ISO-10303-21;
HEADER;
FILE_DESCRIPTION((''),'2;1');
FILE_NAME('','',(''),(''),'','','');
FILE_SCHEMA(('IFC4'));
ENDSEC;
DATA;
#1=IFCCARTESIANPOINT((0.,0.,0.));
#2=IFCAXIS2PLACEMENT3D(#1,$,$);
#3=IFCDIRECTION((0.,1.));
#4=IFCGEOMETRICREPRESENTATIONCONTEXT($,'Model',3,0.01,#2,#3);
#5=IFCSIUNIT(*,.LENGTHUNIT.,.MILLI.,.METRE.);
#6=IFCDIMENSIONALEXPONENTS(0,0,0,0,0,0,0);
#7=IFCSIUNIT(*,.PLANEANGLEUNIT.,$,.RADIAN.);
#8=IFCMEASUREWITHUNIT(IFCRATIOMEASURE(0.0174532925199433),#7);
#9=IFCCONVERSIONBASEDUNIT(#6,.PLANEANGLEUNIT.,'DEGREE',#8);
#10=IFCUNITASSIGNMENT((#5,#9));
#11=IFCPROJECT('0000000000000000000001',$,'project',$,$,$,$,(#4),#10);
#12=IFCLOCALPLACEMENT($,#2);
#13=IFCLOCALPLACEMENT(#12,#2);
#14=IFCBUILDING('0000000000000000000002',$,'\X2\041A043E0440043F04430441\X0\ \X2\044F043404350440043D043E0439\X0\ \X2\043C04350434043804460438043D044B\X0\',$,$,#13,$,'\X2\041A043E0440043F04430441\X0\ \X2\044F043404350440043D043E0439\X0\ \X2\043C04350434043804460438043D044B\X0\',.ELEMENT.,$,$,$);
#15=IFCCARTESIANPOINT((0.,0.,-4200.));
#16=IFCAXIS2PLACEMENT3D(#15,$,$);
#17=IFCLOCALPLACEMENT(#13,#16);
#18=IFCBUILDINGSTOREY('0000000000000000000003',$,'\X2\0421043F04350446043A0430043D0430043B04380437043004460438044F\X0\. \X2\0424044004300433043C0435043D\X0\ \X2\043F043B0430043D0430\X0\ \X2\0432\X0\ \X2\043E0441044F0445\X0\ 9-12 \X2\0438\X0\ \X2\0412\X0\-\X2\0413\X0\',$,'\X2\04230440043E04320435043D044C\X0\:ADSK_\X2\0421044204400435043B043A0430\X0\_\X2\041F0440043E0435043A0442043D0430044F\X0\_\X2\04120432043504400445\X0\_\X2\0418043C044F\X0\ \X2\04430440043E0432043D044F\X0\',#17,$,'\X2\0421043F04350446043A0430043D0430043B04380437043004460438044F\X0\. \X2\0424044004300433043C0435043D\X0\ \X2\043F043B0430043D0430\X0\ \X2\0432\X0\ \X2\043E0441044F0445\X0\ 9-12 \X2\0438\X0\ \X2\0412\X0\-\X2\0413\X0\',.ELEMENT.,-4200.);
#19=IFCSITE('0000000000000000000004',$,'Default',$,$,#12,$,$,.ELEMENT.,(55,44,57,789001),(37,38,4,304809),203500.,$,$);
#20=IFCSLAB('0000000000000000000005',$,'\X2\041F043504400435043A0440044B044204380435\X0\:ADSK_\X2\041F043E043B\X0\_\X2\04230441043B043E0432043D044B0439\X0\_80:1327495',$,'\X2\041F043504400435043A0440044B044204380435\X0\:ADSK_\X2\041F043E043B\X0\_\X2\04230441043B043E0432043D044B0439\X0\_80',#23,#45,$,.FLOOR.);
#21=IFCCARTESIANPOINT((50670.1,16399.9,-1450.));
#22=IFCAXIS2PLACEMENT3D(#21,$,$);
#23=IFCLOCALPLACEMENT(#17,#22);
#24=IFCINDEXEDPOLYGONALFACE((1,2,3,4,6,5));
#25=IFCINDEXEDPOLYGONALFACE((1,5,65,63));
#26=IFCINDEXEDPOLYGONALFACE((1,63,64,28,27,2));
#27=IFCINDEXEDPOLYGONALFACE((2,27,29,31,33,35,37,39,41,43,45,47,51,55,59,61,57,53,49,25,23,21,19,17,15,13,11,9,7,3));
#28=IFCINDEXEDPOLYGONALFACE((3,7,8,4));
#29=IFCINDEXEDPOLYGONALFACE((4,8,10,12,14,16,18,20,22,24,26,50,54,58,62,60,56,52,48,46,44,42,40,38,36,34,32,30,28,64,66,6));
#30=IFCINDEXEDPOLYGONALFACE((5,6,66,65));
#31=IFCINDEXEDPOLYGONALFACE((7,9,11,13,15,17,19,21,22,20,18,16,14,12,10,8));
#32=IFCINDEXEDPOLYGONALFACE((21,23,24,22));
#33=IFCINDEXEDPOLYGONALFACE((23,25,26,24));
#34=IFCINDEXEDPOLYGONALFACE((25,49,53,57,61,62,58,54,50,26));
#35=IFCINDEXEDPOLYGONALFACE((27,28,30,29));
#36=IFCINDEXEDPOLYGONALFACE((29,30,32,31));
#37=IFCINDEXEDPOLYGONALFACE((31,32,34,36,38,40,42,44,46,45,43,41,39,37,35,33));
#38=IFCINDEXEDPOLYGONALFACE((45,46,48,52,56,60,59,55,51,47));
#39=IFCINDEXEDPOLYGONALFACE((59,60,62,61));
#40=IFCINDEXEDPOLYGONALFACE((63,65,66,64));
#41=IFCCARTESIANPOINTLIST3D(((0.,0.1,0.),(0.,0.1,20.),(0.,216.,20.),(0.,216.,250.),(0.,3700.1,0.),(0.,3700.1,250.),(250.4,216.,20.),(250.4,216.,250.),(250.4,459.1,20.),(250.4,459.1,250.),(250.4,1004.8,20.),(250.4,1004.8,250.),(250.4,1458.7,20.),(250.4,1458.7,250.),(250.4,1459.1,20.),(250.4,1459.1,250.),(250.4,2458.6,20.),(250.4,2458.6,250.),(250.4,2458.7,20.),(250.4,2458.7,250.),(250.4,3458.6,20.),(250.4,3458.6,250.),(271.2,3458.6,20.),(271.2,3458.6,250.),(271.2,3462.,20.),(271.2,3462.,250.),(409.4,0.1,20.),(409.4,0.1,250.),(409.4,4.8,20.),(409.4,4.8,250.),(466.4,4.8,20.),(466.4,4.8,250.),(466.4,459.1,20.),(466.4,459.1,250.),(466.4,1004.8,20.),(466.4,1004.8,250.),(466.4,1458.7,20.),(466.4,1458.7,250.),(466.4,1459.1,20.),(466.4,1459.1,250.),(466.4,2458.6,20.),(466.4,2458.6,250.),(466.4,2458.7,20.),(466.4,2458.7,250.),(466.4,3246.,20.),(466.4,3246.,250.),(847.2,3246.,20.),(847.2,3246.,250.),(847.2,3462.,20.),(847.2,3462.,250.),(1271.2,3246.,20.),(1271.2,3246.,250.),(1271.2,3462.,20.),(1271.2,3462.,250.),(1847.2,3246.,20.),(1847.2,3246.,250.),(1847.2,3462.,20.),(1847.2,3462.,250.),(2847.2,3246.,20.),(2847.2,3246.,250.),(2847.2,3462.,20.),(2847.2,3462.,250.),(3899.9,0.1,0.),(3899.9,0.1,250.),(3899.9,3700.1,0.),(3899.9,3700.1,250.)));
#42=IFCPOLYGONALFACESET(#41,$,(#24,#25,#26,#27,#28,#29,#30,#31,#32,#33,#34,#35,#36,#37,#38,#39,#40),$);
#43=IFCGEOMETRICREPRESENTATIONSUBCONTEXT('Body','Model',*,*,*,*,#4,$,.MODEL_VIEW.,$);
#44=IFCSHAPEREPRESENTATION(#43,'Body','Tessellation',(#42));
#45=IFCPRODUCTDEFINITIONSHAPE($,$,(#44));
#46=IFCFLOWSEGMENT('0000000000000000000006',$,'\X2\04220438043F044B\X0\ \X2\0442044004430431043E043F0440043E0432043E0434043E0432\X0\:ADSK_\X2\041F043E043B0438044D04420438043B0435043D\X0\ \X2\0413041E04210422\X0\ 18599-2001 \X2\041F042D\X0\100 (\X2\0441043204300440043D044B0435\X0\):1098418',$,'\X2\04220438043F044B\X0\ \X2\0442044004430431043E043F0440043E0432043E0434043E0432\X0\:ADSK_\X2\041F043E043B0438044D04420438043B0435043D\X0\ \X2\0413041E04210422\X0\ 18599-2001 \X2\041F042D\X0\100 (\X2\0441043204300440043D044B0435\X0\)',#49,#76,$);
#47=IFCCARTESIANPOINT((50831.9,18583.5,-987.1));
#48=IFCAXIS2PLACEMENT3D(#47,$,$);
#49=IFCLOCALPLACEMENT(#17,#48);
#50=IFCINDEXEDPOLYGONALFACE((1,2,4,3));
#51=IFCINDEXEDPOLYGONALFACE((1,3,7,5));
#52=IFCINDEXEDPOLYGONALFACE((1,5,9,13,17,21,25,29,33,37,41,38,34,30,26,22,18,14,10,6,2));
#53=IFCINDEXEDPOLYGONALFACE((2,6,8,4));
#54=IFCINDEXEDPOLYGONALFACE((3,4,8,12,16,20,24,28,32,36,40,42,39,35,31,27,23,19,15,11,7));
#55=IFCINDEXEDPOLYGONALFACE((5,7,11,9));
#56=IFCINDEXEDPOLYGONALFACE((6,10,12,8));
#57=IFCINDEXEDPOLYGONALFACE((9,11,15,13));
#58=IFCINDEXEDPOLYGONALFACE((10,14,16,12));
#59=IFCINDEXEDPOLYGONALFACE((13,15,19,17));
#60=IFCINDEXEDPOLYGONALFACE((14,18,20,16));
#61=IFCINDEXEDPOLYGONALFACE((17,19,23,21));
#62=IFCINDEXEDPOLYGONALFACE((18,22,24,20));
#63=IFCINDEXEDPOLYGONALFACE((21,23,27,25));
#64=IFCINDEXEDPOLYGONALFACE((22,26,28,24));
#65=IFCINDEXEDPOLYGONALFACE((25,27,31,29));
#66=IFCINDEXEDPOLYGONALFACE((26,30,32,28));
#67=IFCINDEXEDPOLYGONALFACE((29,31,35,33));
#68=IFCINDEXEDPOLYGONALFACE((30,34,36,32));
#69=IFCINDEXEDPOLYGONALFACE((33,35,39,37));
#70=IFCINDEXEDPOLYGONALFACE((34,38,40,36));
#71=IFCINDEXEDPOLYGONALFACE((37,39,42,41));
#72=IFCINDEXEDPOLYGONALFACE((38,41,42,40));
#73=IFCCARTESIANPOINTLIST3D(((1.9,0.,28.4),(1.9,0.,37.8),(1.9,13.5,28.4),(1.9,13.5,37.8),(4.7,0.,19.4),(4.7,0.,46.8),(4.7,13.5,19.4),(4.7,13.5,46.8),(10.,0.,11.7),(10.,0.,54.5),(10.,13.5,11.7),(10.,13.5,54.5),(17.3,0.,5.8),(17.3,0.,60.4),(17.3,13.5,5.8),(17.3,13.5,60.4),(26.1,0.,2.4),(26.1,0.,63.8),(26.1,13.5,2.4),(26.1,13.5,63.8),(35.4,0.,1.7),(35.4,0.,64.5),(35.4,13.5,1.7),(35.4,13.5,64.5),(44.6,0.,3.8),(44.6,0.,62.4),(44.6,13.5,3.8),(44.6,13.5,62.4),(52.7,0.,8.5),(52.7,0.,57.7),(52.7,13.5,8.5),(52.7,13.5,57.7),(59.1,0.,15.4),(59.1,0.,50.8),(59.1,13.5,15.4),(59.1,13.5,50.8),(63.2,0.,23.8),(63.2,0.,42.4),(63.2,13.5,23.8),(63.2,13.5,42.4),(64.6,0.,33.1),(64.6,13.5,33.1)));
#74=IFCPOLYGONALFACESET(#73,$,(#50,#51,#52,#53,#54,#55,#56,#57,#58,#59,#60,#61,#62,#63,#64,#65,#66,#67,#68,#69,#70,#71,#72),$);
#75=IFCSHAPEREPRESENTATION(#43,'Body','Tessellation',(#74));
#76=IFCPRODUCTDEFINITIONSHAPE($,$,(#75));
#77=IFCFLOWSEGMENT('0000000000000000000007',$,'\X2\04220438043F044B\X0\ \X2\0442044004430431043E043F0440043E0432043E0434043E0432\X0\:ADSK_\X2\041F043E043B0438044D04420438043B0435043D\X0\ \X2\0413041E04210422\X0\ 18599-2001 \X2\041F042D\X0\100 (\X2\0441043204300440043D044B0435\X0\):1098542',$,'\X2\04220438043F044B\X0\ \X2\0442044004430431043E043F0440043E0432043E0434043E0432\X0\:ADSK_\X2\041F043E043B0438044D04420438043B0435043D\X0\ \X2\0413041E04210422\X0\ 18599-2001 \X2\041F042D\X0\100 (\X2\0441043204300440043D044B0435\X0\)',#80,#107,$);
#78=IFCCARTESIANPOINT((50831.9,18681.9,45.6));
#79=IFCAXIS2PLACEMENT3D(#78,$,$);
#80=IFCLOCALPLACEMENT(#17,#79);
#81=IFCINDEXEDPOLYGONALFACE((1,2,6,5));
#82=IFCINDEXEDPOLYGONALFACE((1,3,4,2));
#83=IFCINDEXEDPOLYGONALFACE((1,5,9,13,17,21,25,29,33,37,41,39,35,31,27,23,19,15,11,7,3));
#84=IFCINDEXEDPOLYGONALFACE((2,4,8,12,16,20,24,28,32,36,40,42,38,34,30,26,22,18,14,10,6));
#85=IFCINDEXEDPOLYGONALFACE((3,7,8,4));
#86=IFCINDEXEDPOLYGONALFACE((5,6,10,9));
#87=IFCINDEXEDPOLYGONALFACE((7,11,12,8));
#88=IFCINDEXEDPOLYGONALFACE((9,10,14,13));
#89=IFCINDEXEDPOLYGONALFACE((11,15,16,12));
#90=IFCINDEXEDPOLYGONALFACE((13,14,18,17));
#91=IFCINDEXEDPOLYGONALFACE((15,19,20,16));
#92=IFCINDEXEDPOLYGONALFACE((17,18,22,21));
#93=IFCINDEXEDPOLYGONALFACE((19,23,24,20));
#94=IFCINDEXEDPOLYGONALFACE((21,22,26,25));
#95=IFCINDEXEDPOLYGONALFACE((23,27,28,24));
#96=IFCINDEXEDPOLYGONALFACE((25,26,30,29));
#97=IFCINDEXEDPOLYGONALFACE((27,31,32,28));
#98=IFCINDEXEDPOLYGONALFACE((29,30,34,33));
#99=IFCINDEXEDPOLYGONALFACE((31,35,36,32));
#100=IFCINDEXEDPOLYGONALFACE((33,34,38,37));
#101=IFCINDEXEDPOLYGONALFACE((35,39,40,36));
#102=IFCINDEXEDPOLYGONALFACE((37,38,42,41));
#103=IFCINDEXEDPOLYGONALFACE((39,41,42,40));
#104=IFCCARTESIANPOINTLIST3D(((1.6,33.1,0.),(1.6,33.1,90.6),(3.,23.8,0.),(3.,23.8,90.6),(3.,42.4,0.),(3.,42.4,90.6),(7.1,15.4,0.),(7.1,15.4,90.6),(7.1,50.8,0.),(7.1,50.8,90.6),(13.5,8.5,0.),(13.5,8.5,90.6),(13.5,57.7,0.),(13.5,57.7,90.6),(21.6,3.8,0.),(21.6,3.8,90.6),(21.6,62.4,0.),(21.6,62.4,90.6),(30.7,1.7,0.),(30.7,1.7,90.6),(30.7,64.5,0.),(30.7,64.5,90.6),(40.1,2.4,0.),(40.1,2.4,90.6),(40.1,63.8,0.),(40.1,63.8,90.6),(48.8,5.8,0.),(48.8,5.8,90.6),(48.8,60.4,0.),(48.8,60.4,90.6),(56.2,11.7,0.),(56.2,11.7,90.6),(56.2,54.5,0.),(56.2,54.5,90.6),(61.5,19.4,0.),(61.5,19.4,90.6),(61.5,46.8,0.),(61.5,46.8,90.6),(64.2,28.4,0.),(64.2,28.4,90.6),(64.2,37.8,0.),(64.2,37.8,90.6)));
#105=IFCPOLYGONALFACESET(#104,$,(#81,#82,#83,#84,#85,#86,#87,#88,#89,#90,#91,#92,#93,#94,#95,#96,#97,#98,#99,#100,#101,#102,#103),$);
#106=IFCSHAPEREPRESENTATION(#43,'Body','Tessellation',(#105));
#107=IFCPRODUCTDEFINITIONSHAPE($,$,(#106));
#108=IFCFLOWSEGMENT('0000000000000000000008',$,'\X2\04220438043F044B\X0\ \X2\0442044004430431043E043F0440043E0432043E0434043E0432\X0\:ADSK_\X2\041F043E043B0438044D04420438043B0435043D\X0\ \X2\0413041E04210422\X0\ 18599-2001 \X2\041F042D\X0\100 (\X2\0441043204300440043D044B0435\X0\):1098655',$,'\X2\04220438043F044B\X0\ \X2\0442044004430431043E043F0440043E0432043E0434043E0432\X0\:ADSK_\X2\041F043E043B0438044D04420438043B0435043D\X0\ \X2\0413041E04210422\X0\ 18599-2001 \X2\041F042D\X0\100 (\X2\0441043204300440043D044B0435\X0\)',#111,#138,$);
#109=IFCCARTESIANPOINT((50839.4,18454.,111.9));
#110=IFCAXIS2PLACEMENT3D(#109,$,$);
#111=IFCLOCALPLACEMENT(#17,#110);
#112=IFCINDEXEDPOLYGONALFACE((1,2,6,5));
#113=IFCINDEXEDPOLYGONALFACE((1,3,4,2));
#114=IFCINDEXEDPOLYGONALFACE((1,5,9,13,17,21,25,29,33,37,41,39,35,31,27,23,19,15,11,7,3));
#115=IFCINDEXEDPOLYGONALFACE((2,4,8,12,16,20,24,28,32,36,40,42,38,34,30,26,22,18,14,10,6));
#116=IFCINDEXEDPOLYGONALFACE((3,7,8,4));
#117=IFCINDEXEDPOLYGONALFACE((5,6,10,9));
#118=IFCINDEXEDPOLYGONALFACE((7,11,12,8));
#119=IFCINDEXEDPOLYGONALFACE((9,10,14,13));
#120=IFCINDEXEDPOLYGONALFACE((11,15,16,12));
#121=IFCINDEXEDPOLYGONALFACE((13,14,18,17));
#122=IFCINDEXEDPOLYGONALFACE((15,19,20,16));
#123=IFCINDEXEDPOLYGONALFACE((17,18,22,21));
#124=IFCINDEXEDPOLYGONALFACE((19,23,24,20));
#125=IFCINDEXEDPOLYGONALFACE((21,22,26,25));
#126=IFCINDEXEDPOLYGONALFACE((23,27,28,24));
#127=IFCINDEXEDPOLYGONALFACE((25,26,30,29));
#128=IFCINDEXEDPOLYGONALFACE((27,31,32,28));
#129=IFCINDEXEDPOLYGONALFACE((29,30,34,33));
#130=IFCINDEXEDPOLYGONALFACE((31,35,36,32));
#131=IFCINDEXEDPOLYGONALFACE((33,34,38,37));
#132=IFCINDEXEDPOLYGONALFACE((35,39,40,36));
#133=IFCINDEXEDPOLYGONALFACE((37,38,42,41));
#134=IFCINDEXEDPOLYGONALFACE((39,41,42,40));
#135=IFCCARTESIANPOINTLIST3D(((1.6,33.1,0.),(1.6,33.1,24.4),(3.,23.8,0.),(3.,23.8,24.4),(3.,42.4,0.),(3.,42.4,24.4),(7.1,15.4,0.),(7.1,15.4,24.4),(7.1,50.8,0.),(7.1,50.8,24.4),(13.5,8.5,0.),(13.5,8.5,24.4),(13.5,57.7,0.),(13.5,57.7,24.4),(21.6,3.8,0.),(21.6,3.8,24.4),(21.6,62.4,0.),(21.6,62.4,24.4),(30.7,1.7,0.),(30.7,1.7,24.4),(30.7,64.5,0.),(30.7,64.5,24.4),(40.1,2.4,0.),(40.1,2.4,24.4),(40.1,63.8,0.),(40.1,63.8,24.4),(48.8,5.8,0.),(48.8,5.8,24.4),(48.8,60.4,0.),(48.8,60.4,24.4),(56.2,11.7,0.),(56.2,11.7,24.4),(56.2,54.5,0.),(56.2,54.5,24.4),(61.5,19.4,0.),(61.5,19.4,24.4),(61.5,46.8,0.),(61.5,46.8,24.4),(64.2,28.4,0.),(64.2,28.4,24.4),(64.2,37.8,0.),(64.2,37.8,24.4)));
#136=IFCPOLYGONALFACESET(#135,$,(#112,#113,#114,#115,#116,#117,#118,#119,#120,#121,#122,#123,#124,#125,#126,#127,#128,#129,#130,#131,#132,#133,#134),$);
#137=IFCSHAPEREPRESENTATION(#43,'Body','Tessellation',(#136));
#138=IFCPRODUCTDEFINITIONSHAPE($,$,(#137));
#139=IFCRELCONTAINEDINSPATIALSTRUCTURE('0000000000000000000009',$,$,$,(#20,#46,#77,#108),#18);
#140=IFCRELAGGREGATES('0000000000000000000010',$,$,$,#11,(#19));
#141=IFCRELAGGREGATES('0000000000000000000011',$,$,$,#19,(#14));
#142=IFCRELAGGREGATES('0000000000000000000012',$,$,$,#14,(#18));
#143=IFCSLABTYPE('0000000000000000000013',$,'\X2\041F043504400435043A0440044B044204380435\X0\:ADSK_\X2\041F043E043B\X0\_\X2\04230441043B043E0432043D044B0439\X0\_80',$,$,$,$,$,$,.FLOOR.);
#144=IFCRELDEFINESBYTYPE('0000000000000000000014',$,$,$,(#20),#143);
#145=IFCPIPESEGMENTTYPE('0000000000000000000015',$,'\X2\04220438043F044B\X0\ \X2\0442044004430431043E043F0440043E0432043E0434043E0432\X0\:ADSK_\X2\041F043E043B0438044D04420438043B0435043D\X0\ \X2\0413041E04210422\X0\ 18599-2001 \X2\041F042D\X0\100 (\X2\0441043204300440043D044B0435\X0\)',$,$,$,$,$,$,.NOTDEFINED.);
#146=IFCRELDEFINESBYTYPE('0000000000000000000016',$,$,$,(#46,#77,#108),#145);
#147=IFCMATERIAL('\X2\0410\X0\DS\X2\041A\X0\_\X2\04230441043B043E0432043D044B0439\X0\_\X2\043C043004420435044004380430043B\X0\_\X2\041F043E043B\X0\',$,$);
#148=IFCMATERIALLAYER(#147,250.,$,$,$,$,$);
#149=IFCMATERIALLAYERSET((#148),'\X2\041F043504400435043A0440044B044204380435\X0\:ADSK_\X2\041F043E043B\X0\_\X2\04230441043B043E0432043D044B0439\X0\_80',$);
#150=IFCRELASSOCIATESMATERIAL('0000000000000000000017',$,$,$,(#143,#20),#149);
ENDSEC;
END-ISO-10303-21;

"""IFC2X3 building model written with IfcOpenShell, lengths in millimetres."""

from ifc_helpers import new_model, entity, si_unit, converted_unit, direction, frame, frame_2d, origin, origin_2d_with_axis, place, context, subcontext, project, spatial, rectangle, circle, extrude, material, layer, layer_set, layer_usage, type_object, element, save


model = new_model("IFC2X3")

# Units and contexts
model_context = context("Model", 3, precision=0.01, world=origin(), true_north=direction((0.0, 1.0)))
body_context = subcontext(model_context, "Body", "Model", "MODEL_VIEW")
ifc_project = project(units=[si_unit("LENGTHUNIT", "METRE", prefix="MILLI"), converted_unit("PLANEANGLEUNIT", "DEGREE", entity("IfcRatioMeasure", 0.0174532925199433), si_unit("PLANEANGLEUNIT", "RADIAN"), dimensions=[0, 0, 0, 0, 0, 0, 0])], contexts=[model_context])

# Site, building, storey
site_placement = place(None, frame((0.0, 0.0, 0.0)))
site = spatial("IfcSite", under=ifc_project, at=site_placement, Name="Default", CompositionType="ELEMENT", RefLatitude=(55, 44, 57, 789001), RefLongitude=(37, 38, 4, 304809), RefElevation=203500.0)
building_placement = place(site_placement, origin())
building = spatial("IfcBuilding", under=site, at=building_placement, Name="Корпус ядерной медицины", LongName="Корпус ядерной медицины", CompositionType="ELEMENT")
storey_placement = place(building_placement, frame((0.0, 0.0, -4200.0)))
storey = spatial("IfcBuildingStorey", under=building, at=storey_placement, Name="Спецканализация. Фрагмен плана в осях 9-12 и В-Г", ObjectType="Уровень:ADSK_Стрелка_Проектная_Вверх_Имя уровня", LongName="Спецканализация. Фрагмен плана в осях 9-12 и В-Г", CompositionType="ELEMENT", Elevation=-4200.0)

# Slab, openings
ifc_material_1 = material(Name="АDSК_Условный_материал_Пол")
ifc_layer = layer(ifc_material_1, 250.0)
ifc_layer_set = layer_set([ifc_layer], Name="Перекрытие:ADSK_Пол_Условный_80")
ifc_layer_usage = layer_usage(ifc_layer_set, "AXIS3", "POSITIVE", 0.0)
slab_type = type_object("IfcSlabType", Name="Перекрытие:ADSK_Пол_Условный_80", PredefinedType="FLOOR", material=ifc_layer_set)
slab_placement = place(storey_placement, frame((50670.1, 16399.9, -1450.0)))
slab = element("IfcSlab", 1, at=slab_placement, inside=storey, type_object=slab_type, material=ifc_layer_usage, Name="Перекрытие:ADSK_Пол_Условный_80:1327495", ObjectType="Перекрытие:ADSK_Пол_Условный_80", PredefinedType="FLOOR", context=body_context, shape_type="SweptSolid", body=[
    extrude(rectangle(XDim=3899.9, YDim=3700.0, at=frame_2d((0.0, 0.0), x_axis=(-1.0, 0.0))), frame((1949.9, 1850.1, 250.0), z_axis=(0.0, 0.0, -1.0), x_axis=(-1.0, 0.0, 0.0)), (0.0, 0.0, 1.0), 250.0),
])
opening_1_placement = place(slab_placement, origin())
element("IfcOpeningElement", 2, at=opening_1_placement, cuts=slab, ObjectType="Opening", context=body_context, shape_type="SweptSolid", body=[
    extrude(rectangle(XDim=1000.0, YDim=216.0, at=origin_2d_with_axis()), frame((771.2, 3354.0, 20.0)), (0.0, 0.0, 1.0), 305.0),
])
opening_2_placement = place(slab_placement, origin())
element("IfcOpeningElement", 3, at=opening_2_placement, cuts=slab, ObjectType="Opening", context=body_context, shape_type="SweptSolid", body=[
    extrude(rectangle(XDim=1000.0, YDim=216.0, at=origin_2d_with_axis()), frame((2347.2, 3354.0, 20.0)), (0.0, 0.0, 1.0), 305.0),
])
opening_3_placement = place(slab_placement, origin())
element("IfcOpeningElement", 4, at=opening_3_placement, cuts=slab, ObjectType="Opening", context=body_context, shape_type="SweptSolid", body=[
    extrude(rectangle(XDim=1000.0, YDim=216.0, at=origin_2d_with_axis()), frame((358.4, 2958.6, 20.0), z_axis=(0.0, 0.0, 1.0), x_axis=(0.0, 1.0, 0.0)), (0.0, 0.0, 1.0), 305.0),
])
opening_4_placement = place(slab_placement, origin())
element("IfcOpeningElement", 5, at=opening_4_placement, cuts=slab, ObjectType="Opening", context=body_context, shape_type="SweptSolid", body=[
    extrude(rectangle(XDim=1000.0, YDim=216.0, at=origin_2d_with_axis()), frame((1347.2, 3354.0, 20.0)), (0.0, 0.0, 1.0), 305.0),
])
opening_5_placement = place(slab_placement, origin())
element("IfcOpeningElement", 6, at=opening_5_placement, cuts=slab, ObjectType="Opening", context=body_context, shape_type="SweptSolid", body=[
    extrude(rectangle(XDim=1000.0, YDim=216.0, at=origin_2d_with_axis()), frame((358.4, 504.8, 20.0), z_axis=(0.0, 0.0, 1.0), x_axis=(0.0, 1.0, 0.0)), (0.0, 0.0, 1.0), 305.0),
])
opening_6_placement = place(slab_placement, origin())
element("IfcOpeningElement", 7, at=opening_6_placement, cuts=slab, ObjectType="Opening", context=body_context, shape_type="SweptSolid", body=[
    extrude(rectangle(XDim=1000.0, YDim=216.0, at=origin_2d_with_axis()), frame((358.4, 1958.7, 20.0), z_axis=(0.0, 0.0, 1.0), x_axis=(0.0, 1.0, 0.0)), (0.0, 0.0, 1.0), 305.0),
])
opening_7_placement = place(slab_placement, origin())
element("IfcOpeningElement", 8, at=opening_7_placement, cuts=slab, ObjectType="Opening", context=body_context, shape_type="SweptSolid", body=[
    extrude(rectangle(XDim=1000.0, YDim=216.0, at=origin_2d_with_axis()), frame((-90.6, 108.0, 20.0), z_axis=(0.0, 0.0, 1.0), x_axis=(-1.0, 0.0, 0.0)), (0.0, 0.0, 1.0), 305.0),
])
opening_8_placement = place(slab_placement, origin())
element("IfcOpeningElement", 9, at=opening_8_placement, cuts=slab, ObjectType="Opening", context=body_context, shape_type="SweptSolid", body=[
    extrude(rectangle(XDim=1000.0, YDim=216.0, at=origin_2d_with_axis()), frame((358.4, 959.1, 20.0), z_axis=(0.0, 0.0, 1.0), x_axis=(0.0, 1.0, 0.0)), (0.0, 0.0, 1.0), 305.0),
])

# Flow segments
pipe_segment_type = type_object("IfcPipeSegmentType", Name="Типы трубопроводов:ADSK_Полиэтилен ГОСТ 18599-2001 ПЭ100 (сварные)", PredefinedType="NOTDEFINED")
flow_segment_1_placement = place(storey_placement, frame((50831.9, 18583.5, -987.1)))
element("IfcFlowSegment", 10, at=flow_segment_1_placement, inside=storey, type_object=pipe_segment_type, Name="Типы трубопроводов:ADSK_Полиэтилен ГОСТ 18599-2001 ПЭ100 (сварные):1098418", ObjectType="Типы трубопроводов:ADSK_Полиэтилен ГОСТ 18599-2001 ПЭ100 (сварные)", context=body_context, shape_type="SweptSolid", body=[
    extrude(circle(Radius=31.5, at=origin_2d_with_axis()), frame((33.1, 0.0, 33.1), z_axis=(0.0, 1.0, 0.0), x_axis=(1.0, 0.0, 0.0)), (0.0, 0.0, 1.0), 13.5),
])
flow_segment_2_placement = place(storey_placement, frame((50831.9, 18681.9, 45.6)))
element("IfcFlowSegment", 11, at=flow_segment_2_placement, inside=storey, type_object=pipe_segment_type, Name="Типы трубопроводов:ADSK_Полиэтилен ГОСТ 18599-2001 ПЭ100 (сварные):1098542", ObjectType="Типы трубопроводов:ADSK_Полиэтилен ГОСТ 18599-2001 ПЭ100 (сварные)", context=body_context, shape_type="SweptSolid", body=[
    extrude(circle(Radius=31.5, at=origin_2d_with_axis()), frame((33.1, 33.1, 0.0), z_axis=(0.0, 0.0, 1.0), x_axis=(-1.0, 0.0, 0.0)), (0.0, 0.0, 1.0), 90.6),
])
flow_segment_3_placement = place(storey_placement, frame((50839.4, 18454.0, 111.9)))
element("IfcFlowSegment", 12, at=flow_segment_3_placement, inside=storey, type_object=pipe_segment_type, Name="Типы трубопроводов:ADSK_Полиэтилен ГОСТ 18599-2001 ПЭ100 (сварные):1098655", ObjectType="Типы трубопроводов:ADSK_Полиэтилен ГОСТ 18599-2001 ПЭ100 (сварные)", context=body_context, shape_type="SweptSolid", body=[
    extrude(circle(Radius=31.5, at=frame_2d((0.0, 0.0), x_axis=(1.0, 0.0))), frame((33.1, 33.1, 0.0), z_axis=(0.0, 0.0, 1.0), x_axis=(-1.0, 0.0, 0.0)), (0.0, 0.0, 1.0), 24.4),
])

save(model, "model.ifc")
